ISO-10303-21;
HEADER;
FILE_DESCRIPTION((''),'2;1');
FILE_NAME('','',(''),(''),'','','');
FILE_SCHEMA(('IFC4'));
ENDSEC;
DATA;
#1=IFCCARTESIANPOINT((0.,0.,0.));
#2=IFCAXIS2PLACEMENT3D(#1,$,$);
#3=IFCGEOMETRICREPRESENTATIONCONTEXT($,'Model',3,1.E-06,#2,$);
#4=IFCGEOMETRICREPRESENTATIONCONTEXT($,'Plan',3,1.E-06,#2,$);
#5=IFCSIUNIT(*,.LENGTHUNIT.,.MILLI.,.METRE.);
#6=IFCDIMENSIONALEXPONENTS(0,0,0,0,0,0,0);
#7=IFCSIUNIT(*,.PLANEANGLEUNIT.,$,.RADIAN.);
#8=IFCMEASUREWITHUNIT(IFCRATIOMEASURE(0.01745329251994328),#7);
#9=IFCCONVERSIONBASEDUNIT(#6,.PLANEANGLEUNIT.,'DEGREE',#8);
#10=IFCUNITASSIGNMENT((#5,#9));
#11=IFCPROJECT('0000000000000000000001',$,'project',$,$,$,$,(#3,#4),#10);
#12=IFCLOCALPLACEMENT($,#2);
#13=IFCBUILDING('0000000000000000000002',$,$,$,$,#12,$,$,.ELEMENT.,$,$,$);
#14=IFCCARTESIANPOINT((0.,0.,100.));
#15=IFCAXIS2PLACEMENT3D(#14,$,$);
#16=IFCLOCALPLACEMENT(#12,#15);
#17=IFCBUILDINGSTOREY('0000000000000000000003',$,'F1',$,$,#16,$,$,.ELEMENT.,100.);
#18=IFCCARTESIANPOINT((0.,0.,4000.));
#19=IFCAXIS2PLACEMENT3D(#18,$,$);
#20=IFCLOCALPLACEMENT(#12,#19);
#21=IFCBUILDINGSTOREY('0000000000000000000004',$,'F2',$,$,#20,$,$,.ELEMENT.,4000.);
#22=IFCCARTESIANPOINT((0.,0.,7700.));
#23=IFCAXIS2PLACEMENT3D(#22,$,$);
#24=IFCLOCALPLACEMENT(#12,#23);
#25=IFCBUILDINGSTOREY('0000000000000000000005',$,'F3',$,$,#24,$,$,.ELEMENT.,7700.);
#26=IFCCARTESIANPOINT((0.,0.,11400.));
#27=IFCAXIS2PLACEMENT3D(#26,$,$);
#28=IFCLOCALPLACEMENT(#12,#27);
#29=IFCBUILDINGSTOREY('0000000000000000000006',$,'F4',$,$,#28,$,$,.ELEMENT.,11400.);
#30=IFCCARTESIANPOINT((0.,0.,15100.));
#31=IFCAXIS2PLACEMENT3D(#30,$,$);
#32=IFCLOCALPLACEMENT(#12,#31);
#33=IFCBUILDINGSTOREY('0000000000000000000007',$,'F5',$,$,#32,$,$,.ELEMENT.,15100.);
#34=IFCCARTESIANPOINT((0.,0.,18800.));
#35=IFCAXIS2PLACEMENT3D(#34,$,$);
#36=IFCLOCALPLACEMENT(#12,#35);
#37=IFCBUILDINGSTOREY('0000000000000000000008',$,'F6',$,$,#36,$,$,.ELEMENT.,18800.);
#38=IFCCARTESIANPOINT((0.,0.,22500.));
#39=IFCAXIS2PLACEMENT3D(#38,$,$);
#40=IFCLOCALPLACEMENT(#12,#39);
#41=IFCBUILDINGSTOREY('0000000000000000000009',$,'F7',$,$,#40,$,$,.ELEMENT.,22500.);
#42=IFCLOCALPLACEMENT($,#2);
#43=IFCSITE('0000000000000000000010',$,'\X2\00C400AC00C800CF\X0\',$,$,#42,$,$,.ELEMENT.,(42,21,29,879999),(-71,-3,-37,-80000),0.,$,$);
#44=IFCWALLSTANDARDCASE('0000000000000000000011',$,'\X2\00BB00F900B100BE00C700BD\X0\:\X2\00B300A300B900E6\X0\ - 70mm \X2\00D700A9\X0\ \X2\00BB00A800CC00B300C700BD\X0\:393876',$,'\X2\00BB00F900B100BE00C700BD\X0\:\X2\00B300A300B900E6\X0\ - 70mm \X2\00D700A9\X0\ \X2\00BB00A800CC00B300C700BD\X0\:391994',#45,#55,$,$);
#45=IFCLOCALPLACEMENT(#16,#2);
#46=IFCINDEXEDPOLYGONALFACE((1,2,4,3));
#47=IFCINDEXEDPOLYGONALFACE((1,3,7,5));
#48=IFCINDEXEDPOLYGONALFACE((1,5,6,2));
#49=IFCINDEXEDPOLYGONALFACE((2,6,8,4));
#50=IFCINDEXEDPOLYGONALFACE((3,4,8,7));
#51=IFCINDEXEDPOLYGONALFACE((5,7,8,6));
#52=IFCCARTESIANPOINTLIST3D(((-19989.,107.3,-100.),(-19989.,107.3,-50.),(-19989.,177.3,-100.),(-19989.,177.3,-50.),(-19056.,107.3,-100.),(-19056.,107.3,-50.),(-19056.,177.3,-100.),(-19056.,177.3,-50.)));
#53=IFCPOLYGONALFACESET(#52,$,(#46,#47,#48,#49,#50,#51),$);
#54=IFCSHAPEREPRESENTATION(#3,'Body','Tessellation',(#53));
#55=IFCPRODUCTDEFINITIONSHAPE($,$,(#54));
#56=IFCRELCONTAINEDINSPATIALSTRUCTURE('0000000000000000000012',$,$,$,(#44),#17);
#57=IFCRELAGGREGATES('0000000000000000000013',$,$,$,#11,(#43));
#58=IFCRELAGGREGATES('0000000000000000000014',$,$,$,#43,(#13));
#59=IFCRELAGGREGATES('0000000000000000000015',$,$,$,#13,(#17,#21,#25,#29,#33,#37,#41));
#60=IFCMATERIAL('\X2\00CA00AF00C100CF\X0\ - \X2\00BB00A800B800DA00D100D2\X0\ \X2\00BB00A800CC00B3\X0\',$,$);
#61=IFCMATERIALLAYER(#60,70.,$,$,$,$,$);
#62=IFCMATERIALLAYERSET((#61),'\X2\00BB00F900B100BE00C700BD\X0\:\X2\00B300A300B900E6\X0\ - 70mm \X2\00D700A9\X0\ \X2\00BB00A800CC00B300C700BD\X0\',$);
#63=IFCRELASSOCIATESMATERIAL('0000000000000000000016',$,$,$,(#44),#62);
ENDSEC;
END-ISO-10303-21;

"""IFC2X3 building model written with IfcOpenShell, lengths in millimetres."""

from ifc_helpers import new_model, entity, si_unit, converted_unit, frame, frame_2d, origin, place, context, project, spatial, rectangle, extrude, material, layer, layer_set, layer_usage, element, save


model = new_model("IFC2X3")

# Units and contexts
model_context = context("Model", 3, precision=1e-06, world=origin())
plan_context = context("Plan", 3, precision=1e-06, world=origin())
ifc_project = project(units=[si_unit("LENGTHUNIT", "METRE", prefix="MILLI"), converted_unit("PLANEANGLEUNIT", "DEGREE", entity("IfcRatioMeasure", 0.01745329251994328), si_unit("PLANEANGLEUNIT", "RADIAN"), dimensions=[0, 0, 0, 0, 0, 0, 0])], contexts=[model_context, plan_context])

# Site, building, storey
site_placement = place(None, origin())
site = spatial("IfcSite", under=ifc_project, at=site_placement, Name="Ä¬ÈÏ", CompositionType="ELEMENT", RefLatitude=(42, 21, 29, 879999), RefLongitude=(-71, -3, -37, -80000), RefElevation=0.0)
building_placement = place(None, origin())
building = spatial("IfcBuilding", under=site, at=building_placement, CompositionType="ELEMENT")
storey_1_placement = place(building_placement, frame((0.0, 0.0, 100.0)))
storey_1 = spatial("IfcBuildingStorey", under=building, at=storey_1_placement, Name="F1", CompositionType="ELEMENT", Elevation=100.0)

# Shared definitions
storey_2_placement = place(building_placement, frame((0.0, 0.0, 4000.0)))
storey_2 = spatial("IfcBuildingStorey", under=building, at=storey_2_placement, Name="F2", CompositionType="ELEMENT", Elevation=4000.0)

# Shared definitions
storey_3_placement = place(building_placement, frame((0.0, 0.0, 7700.0)))
storey_3 = spatial("IfcBuildingStorey", under=building, at=storey_3_placement, Name="F3", CompositionType="ELEMENT", Elevation=7700.0)

# Shared definitions
storey_4_placement = place(building_placement, frame((0.0, 0.0, 11400.0)))
storey_4 = spatial("IfcBuildingStorey", under=building, at=storey_4_placement, Name="F4", CompositionType="ELEMENT", Elevation=11400.0)

# Shared definitions
storey_5_placement = place(building_placement, frame((0.0, 0.0, 15100.0)))
storey_5 = spatial("IfcBuildingStorey", under=building, at=storey_5_placement, Name="F5", CompositionType="ELEMENT", Elevation=15100.0)

# Shared definitions
storey_6_placement = place(building_placement, frame((0.0, 0.0, 18800.0)))
storey_6 = spatial("IfcBuildingStorey", under=building, at=storey_6_placement, Name="F6", CompositionType="ELEMENT", Elevation=18800.0)

# Shared definitions
storey_7_placement = place(building_placement, frame((0.0, 0.0, 22500.0)))
storey_7 = spatial("IfcBuildingStorey", under=building, at=storey_7_placement, Name="F7", CompositionType="ELEMENT", Elevation=22500.0)

# Wall
ifc_material_1 = material(Name="Ê¯ÁÏ - »¨¸ÚÑÒ »¨Ì³")
ifc_layer_1 = layer(ifc_material_1, 70.0)
ifc_layer_set_1 = layer_set([ifc_layer_1], Name="»ù±¾Ç½:³£¹æ - 70mm ×© »¨Ì³Ç½")
ifc_layer_usage_1 = layer_usage(ifc_layer_set_1, "AXIS2", "NEGATIVE", 35.0)
wall_1_placement = place(storey_1_placement, frame((-19056.0, 142.3, -100.0), z_axis=(0.0, 0.0, 1.0), x_axis=(-1.0, 0.0, 0.0)))
element("IfcWallStandardCase", 1, at=wall_1_placement, inside=storey_1, material=ifc_layer_usage_1, Name="»ù±¾Ç½:³£¹æ - 70mm ×© »¨Ì³Ç½:393876", ObjectType="»ù±¾Ç½:³£¹æ - 70mm ×© »¨Ì³Ç½:391994", context=model_context, shape_type="SweptSolid", body=[
    extrude(rectangle(XDim=932.9, YDim=70.0, at=frame_2d((466.5, 0.0), x_axis=(-1.0, 0.0))), origin(), (0.0, 0.0, 1.0), 50.0),
])

save(model, "model.ifc")
